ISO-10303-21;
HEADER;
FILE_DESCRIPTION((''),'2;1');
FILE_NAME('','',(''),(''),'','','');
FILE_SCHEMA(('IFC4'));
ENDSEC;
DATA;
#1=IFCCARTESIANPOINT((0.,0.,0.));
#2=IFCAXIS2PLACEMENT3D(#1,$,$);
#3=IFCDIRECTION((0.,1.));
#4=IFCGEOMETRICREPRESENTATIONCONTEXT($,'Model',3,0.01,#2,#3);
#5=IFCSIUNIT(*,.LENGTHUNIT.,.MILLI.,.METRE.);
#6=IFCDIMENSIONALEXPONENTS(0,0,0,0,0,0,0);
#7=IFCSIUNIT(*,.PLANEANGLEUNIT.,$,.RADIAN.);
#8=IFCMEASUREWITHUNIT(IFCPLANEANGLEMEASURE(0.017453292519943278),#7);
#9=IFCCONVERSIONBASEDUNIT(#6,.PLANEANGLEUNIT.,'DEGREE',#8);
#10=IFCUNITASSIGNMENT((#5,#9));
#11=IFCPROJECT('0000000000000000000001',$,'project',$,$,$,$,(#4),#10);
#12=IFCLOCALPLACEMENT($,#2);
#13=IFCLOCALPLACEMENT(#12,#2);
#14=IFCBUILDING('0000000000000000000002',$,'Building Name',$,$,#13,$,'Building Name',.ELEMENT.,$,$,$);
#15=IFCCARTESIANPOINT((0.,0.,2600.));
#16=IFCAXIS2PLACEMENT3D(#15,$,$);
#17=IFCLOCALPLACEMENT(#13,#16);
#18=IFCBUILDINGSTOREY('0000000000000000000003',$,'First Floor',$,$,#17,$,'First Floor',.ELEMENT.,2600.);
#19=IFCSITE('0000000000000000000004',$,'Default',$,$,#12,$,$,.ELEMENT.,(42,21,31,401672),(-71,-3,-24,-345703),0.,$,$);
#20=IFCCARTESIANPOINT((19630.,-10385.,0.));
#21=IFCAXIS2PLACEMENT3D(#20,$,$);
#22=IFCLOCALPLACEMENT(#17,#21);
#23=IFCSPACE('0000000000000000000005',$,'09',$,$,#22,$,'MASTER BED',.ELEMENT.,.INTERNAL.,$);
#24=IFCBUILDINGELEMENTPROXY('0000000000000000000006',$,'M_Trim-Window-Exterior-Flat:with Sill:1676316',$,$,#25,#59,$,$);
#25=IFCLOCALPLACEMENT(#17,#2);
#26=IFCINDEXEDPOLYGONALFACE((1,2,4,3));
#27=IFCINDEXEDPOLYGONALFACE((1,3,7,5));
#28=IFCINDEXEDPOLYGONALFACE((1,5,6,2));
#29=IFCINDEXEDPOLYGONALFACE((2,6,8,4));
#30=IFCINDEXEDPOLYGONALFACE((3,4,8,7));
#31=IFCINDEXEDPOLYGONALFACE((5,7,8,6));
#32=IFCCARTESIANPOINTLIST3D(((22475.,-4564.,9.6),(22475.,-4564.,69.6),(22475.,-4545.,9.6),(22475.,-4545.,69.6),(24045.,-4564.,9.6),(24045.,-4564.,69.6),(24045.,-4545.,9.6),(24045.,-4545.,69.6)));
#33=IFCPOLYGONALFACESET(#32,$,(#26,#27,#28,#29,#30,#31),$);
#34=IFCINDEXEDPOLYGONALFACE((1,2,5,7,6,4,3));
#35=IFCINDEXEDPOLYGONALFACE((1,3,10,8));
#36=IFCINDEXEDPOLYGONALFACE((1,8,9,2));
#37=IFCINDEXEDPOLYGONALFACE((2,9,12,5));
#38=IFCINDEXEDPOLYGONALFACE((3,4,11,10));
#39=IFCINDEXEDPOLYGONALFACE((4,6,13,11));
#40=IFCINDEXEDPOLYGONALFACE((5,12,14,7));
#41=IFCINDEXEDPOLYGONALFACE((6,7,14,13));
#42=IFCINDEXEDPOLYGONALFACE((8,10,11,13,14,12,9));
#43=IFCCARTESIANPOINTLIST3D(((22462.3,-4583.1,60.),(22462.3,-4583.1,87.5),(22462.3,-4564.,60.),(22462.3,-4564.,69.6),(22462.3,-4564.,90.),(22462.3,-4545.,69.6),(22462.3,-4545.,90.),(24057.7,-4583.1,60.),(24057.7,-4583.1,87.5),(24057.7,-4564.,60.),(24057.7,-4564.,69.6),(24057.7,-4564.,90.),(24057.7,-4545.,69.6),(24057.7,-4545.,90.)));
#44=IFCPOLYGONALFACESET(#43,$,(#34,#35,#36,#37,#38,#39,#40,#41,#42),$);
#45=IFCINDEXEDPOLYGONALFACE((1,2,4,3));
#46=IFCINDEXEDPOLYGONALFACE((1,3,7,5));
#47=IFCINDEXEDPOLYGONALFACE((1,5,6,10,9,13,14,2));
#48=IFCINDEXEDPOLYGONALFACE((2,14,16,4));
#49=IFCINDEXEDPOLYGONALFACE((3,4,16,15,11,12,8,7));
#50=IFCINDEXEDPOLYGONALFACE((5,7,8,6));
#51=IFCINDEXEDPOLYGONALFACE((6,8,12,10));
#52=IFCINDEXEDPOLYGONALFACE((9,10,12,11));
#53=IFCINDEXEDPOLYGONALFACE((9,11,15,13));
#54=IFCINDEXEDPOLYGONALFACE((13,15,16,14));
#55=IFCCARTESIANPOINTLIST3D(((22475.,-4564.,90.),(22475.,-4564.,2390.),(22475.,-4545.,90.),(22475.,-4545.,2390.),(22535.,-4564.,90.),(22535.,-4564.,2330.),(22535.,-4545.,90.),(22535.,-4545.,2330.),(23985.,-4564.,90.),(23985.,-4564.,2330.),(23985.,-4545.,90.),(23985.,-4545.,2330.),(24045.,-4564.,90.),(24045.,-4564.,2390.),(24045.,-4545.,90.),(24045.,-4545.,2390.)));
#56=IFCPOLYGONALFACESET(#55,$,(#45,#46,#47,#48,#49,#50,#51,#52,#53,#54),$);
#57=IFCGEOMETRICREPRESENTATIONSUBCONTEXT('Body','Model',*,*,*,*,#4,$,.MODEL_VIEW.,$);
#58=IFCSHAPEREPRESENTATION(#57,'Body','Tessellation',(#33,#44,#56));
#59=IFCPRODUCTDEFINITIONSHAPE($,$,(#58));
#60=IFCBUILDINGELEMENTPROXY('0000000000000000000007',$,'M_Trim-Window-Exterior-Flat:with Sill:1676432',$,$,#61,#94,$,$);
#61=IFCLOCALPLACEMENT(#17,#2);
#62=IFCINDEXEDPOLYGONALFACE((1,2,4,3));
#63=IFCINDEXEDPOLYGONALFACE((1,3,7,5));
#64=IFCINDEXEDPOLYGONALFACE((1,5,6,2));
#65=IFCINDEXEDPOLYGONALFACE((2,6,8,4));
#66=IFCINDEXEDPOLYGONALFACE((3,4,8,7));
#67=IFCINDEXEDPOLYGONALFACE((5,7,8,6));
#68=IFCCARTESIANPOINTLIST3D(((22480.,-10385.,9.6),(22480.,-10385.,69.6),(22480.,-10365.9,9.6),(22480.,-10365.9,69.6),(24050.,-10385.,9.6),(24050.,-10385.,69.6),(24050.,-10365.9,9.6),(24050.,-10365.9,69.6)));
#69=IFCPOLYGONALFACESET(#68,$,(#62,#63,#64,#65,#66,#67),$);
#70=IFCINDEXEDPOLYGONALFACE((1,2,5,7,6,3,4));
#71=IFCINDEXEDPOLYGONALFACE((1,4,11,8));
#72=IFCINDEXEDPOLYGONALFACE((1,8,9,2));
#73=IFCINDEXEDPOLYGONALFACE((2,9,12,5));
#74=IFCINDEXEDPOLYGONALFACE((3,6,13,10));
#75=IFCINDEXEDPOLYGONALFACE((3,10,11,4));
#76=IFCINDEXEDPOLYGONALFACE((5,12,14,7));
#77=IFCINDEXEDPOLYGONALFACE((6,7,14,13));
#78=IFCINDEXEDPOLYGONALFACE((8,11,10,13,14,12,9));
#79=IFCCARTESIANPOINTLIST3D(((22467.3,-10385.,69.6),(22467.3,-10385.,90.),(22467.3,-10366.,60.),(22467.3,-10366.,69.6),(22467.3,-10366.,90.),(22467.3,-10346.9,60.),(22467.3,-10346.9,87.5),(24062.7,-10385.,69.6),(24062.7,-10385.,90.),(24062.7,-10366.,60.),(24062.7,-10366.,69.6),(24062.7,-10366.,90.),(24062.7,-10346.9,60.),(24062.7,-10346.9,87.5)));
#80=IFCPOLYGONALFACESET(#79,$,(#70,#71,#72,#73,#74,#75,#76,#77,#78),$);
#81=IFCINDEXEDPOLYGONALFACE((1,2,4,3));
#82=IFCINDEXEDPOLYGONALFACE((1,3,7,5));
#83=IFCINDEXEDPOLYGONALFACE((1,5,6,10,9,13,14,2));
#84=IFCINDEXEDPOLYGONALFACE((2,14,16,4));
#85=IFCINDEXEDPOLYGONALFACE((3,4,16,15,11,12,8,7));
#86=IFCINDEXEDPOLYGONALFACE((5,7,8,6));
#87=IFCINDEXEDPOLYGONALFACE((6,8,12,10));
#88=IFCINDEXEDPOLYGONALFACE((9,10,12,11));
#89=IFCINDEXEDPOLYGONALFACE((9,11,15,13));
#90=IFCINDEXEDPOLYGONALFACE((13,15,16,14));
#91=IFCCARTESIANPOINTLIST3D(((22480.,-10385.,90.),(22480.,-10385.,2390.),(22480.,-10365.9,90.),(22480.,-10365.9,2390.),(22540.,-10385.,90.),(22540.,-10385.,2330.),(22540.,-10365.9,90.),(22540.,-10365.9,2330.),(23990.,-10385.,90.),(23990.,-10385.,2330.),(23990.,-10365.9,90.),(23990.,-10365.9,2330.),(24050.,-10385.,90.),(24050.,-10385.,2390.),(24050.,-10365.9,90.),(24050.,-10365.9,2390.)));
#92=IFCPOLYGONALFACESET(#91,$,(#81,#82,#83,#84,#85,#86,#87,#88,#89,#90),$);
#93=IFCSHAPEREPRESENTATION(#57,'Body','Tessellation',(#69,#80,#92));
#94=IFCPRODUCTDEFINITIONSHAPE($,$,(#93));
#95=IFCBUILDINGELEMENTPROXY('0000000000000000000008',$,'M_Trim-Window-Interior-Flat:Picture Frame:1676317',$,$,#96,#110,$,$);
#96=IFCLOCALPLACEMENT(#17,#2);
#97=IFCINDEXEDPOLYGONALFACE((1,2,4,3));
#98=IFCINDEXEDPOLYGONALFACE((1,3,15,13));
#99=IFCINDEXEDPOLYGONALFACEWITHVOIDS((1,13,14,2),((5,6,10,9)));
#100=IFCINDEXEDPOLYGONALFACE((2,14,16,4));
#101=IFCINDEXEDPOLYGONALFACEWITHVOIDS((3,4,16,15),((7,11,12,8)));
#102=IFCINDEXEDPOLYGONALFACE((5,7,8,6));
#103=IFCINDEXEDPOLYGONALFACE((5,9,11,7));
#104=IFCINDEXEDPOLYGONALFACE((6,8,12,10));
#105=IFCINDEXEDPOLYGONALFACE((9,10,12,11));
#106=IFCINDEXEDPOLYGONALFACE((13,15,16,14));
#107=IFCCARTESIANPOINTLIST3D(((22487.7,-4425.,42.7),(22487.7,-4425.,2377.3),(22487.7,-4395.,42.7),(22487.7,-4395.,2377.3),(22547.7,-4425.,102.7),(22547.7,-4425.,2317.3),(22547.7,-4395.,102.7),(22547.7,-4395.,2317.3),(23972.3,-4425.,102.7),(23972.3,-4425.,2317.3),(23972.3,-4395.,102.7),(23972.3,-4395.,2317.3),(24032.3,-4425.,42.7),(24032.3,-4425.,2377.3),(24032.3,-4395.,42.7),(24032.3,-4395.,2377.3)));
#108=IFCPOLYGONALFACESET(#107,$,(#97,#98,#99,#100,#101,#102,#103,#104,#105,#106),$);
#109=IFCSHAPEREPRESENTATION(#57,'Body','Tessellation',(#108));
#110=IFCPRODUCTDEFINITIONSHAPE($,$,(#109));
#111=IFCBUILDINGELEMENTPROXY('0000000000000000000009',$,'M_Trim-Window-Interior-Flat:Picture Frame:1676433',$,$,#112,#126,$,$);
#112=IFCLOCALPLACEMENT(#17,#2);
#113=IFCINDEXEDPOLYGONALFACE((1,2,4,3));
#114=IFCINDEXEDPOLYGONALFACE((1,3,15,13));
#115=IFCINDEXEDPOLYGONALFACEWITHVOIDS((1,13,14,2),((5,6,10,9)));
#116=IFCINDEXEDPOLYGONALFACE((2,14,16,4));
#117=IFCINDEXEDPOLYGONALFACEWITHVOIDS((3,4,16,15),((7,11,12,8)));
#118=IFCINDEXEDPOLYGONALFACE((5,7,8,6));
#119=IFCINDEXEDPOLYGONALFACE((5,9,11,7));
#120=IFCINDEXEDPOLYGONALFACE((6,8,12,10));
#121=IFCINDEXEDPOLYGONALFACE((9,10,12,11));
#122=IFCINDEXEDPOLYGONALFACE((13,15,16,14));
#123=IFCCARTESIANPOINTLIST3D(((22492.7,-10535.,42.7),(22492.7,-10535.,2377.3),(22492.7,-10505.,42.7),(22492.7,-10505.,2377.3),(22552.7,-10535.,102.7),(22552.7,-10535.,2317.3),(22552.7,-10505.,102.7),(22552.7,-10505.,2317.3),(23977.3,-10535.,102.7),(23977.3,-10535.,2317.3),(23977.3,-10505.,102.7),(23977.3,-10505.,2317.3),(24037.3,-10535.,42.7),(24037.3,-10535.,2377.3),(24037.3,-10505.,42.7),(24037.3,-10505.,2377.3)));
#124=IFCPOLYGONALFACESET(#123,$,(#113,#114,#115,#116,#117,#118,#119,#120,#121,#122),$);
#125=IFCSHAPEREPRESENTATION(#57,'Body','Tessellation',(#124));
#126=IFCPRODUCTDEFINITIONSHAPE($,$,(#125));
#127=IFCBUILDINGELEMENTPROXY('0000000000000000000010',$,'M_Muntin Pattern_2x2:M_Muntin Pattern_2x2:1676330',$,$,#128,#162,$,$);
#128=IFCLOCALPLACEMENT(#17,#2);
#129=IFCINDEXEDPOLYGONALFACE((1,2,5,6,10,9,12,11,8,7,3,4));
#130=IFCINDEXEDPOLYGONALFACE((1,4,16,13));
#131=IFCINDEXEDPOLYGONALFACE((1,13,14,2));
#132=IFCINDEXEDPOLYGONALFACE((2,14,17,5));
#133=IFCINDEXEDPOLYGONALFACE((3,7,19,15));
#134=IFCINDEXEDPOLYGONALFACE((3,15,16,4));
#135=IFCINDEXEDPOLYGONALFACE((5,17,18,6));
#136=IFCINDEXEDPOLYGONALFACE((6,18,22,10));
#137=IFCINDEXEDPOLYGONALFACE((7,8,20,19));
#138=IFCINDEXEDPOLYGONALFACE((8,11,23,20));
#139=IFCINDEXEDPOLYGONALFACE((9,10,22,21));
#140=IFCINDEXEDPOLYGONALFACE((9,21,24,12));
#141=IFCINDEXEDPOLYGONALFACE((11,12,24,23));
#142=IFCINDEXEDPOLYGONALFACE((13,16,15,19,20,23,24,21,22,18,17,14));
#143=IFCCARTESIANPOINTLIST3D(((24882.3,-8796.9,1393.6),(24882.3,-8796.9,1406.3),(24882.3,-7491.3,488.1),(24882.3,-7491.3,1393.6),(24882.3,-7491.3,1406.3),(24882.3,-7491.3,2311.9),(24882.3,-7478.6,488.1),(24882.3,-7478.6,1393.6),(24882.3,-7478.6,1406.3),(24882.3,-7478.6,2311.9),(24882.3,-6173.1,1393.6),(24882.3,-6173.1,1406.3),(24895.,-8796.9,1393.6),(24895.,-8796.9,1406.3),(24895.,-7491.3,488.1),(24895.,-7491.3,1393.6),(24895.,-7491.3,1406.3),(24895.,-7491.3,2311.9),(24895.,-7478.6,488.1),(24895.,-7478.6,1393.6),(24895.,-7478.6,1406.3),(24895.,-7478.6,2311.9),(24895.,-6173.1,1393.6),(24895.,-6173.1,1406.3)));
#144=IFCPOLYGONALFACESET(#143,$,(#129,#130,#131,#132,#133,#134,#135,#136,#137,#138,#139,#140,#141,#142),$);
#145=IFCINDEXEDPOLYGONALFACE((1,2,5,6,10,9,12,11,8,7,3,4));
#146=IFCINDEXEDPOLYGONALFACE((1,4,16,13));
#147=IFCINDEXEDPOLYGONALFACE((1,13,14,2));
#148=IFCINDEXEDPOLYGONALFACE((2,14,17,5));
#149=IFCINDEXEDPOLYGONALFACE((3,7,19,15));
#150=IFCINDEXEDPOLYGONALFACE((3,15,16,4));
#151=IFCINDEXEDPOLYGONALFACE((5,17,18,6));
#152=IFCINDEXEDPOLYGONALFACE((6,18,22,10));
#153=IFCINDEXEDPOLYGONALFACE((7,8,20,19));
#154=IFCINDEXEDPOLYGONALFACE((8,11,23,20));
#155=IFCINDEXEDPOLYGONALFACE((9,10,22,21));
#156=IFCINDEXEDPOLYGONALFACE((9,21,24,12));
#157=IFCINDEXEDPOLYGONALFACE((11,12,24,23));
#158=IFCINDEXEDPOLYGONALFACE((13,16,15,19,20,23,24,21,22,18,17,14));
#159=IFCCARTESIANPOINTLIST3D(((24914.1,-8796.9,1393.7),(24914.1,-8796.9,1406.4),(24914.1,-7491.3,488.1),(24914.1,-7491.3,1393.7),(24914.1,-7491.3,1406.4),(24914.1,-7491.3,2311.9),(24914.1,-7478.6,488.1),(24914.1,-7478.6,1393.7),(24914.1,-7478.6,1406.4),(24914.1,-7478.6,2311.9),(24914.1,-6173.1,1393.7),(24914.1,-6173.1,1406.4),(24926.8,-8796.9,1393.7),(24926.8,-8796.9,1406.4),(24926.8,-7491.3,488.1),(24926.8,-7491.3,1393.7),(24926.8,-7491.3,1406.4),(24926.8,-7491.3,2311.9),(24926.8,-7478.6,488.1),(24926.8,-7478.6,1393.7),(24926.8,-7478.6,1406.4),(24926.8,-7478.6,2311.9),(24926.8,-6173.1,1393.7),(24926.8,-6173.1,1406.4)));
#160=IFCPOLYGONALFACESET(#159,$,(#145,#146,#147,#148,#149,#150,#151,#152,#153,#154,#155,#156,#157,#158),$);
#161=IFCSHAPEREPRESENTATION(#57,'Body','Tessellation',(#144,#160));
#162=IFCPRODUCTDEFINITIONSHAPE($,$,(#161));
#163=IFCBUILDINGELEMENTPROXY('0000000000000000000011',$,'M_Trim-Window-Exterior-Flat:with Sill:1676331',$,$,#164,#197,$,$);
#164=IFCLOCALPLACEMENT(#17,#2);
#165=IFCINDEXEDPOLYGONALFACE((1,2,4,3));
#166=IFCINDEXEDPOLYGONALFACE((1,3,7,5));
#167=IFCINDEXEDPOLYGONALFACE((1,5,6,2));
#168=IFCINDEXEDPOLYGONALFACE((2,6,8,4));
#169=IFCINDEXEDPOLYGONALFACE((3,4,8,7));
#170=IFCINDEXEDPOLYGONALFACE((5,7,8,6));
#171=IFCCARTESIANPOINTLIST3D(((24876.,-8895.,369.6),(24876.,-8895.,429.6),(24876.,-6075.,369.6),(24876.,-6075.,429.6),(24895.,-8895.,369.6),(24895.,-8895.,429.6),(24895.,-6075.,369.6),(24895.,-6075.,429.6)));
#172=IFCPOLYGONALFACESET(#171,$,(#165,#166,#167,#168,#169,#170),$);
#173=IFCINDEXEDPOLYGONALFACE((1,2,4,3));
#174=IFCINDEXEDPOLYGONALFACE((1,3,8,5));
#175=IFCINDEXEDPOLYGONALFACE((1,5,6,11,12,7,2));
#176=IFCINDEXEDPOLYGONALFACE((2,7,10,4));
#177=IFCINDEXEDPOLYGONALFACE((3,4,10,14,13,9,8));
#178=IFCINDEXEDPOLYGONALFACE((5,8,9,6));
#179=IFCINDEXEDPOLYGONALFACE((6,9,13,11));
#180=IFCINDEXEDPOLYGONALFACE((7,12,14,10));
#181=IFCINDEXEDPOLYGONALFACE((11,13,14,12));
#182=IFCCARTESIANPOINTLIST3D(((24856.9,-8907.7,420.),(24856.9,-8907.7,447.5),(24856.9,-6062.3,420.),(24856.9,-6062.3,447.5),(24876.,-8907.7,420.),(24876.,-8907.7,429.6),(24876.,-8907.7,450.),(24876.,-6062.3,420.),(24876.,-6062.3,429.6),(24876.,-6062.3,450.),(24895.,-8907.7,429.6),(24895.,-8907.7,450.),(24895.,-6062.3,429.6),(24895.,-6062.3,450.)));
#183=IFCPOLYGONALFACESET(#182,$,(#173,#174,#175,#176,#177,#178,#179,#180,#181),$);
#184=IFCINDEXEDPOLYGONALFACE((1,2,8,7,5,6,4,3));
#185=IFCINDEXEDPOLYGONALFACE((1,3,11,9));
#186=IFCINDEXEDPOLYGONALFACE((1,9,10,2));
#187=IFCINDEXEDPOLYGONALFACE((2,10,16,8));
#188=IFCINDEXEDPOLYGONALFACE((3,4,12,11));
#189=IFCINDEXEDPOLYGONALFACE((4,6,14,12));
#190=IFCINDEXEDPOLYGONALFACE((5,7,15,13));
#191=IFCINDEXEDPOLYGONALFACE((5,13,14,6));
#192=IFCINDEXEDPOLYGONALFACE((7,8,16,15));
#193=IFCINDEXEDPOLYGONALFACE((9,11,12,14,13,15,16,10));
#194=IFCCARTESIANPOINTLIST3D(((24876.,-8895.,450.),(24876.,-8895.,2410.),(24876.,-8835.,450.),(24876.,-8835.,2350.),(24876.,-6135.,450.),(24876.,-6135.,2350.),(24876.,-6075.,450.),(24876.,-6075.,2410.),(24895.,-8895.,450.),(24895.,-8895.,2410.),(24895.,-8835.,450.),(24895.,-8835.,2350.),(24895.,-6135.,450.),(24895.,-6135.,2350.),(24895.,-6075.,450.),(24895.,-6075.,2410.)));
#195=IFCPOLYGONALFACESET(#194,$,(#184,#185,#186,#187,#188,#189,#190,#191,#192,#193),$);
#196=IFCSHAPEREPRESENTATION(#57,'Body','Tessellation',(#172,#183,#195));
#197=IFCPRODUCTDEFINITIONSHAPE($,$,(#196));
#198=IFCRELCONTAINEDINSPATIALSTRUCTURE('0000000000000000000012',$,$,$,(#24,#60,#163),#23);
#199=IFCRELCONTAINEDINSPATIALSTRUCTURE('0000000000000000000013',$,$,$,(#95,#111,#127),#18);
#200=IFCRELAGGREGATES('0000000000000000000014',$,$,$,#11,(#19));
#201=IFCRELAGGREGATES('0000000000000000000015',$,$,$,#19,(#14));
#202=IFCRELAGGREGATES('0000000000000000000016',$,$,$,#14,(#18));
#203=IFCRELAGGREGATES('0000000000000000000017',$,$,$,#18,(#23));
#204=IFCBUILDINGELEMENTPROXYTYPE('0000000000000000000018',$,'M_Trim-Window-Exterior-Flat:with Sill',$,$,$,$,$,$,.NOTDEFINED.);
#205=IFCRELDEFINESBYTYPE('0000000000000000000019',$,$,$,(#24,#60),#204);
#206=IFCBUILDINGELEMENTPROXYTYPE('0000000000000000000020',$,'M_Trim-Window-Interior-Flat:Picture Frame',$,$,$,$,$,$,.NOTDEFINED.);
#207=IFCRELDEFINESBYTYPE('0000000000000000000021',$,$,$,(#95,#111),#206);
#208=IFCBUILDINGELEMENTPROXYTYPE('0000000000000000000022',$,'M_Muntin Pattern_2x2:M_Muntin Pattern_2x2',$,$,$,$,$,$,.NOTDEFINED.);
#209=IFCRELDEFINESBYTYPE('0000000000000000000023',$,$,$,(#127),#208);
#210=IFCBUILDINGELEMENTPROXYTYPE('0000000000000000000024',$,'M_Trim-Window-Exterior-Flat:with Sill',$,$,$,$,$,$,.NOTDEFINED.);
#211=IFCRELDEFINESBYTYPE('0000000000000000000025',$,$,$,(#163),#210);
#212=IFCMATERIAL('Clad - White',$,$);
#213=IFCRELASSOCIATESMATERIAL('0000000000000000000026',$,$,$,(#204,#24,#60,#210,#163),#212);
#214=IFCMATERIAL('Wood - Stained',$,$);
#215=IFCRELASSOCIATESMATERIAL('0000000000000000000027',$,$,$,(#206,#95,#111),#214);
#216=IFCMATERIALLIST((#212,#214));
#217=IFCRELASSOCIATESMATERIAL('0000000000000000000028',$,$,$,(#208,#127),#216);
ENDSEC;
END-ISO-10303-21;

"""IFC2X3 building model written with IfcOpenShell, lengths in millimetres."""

from ifc_helpers import new_model, entity, si_unit, converted_unit, direction, frame, frame_2d, origin, place, context, subcontext, project, spatial, polyline, rectangle, outline, extrude, source, transform, mapped, material, material_list, type_object, type_shapes, element, save


model = new_model("IFC2X3")

# Units and contexts
model_context = context("Model", 3, precision=0.01, world=origin(), true_north=direction((0.0, 1.0)))
body_context = subcontext(model_context, "Body", "Model", "MODEL_VIEW")
ifc_project = project(units=[si_unit("LENGTHUNIT", "METRE", prefix="MILLI"), converted_unit("PLANEANGLEUNIT", "DEGREE", entity("IfcPlaneAngleMeasure", 0.017453292519943278), si_unit("PLANEANGLEUNIT", "RADIAN"), dimensions=[0, 0, 0, 0, 0, 0, 0])], contexts=[model_context])

# Site, building, storey
site_placement = place(None, origin())
site = spatial("IfcSite", under=ifc_project, at=site_placement, Name="Default", CompositionType="ELEMENT", RefLatitude=(42, 21, 31, 401672), RefLongitude=(-71, -3, -24, -345703), RefElevation=0.0)
building_placement = place(site_placement, origin())
building = spatial("IfcBuilding", under=site, at=building_placement, Name="Building Name", LongName="Building Name", CompositionType="ELEMENT")
storey_placement = place(building_placement, frame((0.0, 0.0, 2600.0)))
storey = spatial("IfcBuildingStorey", under=building, at=storey_placement, Name="First Floor", LongName="First Floor", CompositionType="ELEMENT", Elevation=2600.0)

# Shared definitions
space_placement = place(storey_placement, frame((19630.0, -10385.0, 0.0)))
space = spatial("IfcSpace", under=storey, at=space_placement, Name="09", LongName="MASTER BED", CompositionType="ELEMENT", InteriorOrExteriorSpace="INTERNAL")

# Building element proxies
ifc_material_1 = material(Name="Clad - White")
ifc_material_2 = material(Name="Wood - Stained")
ifc_material_list = material_list([ifc_material_1, ifc_material_2])
building_element_proxy_type_1 = type_object("IfcBuildingElementProxyType", Name="M_Trim-Window-Exterior-Flat:with Sill", PredefinedType="NOTDEFINED", material=ifc_material_1)
shared_shape_1 = source(origin(), body_context, "Body", "SweptSolid", [
    extrude(rectangle(XDim=1570.0, YDim=60.0, at=frame_2d((0.0, 0.0), x_axis=(1.0, 0.0))), frame((0.0, -2290.4, 0.0), z_axis=(0.0, 0.0, 1.0), x_axis=(-1.0, 0.0, 0.0)), (0.0, 0.0, 1.0), 19.0),
    extrude(outline(polyline([(-19.0, -15.2), (0.0, -15.2), (0.0, -5.7), (19.0, -5.7), (19.0, 14.8), (0.0, 14.8), (-19.0, 12.3), (-19.0, -15.2)])), frame((-797.7, -2254.8, 19.0), z_axis=(1.0, 0.0, 0.0), x_axis=(0.0, 0.0, -1.0)), (0.0, 0.0, 1.0), 1595.4),
    extrude(outline(polyline([(-1165.0, -785.0), (1135.0, -785.0), (1135.0, -725.0), (-1105.0, -725.0), (-1105.0, 725.0), (1135.0, 725.0), (1135.0, 785.0), (-1165.0, 785.0), (-1165.0, -785.0)])), frame((0.0, -1105.0, 0.0), z_axis=(0.0, 0.0, 1.0), x_axis=(0.0, -1.0, 0.0)), (0.0, 0.0, 1.0), 19.0),
])
type_shapes(building_element_proxy_type_1, [shared_shape_1])
for number, where, z_axis, x_axis, name in (
    (1, (3630.0, 5840.0, 2330.0), (0.0, -1.0, 0.0), (1.0, 0.0, 0.0), "M_Trim-Window-Exterior-Flat:with Sill:1676316"),
    (2, (3635.0, 0.0, 2330.0), (0.0, 1.0, 0.0), (-1.0, 0.0, 0.0), "M_Trim-Window-Exterior-Flat:with Sill:1676432"),
):
    element("IfcBuildingElementProxy", number, at=place(space_placement, frame(where, z_axis=z_axis, x_axis=x_axis)), inside=space, type_object=building_element_proxy_type_1, material=ifc_material_1, Name=name, context=body_context, shape_type="MappedRepresentation", body=[
        mapped(shared_shape_1, transform((0.0, 0.0, 0.0), scale=1.0)),
    ])
building_element_proxy_type_2 = type_object("IfcBuildingElementProxyType", Name="M_Trim-Window-Interior-Flat:Picture Frame", PredefinedType="NOTDEFINED", material=ifc_material_2)
shared_shape_2 = source(origin(), body_context, "Body", "SweptSolid", [
    extrude(outline(polyline([(-772.3, -1167.3), (772.3, -1167.3), (772.3, 1167.3), (-772.3, 1167.3), (-772.3, -1167.3)]), holes=[polyline([(-712.3, -1107.3), (-712.3, 1107.3), (712.3, 1107.3), (712.3, -1107.3), (-712.3, -1107.3)])]), frame((0.0, -1120.0, 0.0), z_axis=(0.0, 0.0, 1.0), x_axis=(-1.0, 0.0, 0.0)), (0.0, 0.0, 1.0), 30.0),
])
type_shapes(building_element_proxy_type_2, [shared_shape_2])
for number, where, z_axis, x_axis, name in (
    (3, (23260.0, -4425.0, 2330.0), (0.0, 1.0, 0.0), (-1.0, 0.0, 0.0), "M_Trim-Window-Interior-Flat:Picture Frame:1676317"),
    (4, (23265.0, -10505.0, 2330.0), (0.0, -1.0, 0.0), (1.0, 0.0, 0.0), "M_Trim-Window-Interior-Flat:Picture Frame:1676433"),
):
    element("IfcBuildingElementProxy", number, at=place(storey_placement, frame(where, z_axis=z_axis, x_axis=x_axis)), inside=storey, type_object=building_element_proxy_type_2, material=ifc_material_2, Name=name, context=body_context, shape_type="MappedRepresentation", body=[
        mapped(shared_shape_2, transform((0.0, 0.0, 0.0), scale=1.0)),
    ])
building_element_proxy_type_3 = type_object("IfcBuildingElementProxyType", Name="M_Muntin Pattern_2x2:M_Muntin Pattern_2x2", PredefinedType="NOTDEFINED", material=ifc_material_list)
shared_shape_3 = source(origin(), body_context, "Body", "SweptSolid", [
    extrude(outline(polyline([(6.4, -6.4), (911.9, -6.4), (911.9, 6.3), (6.4, 6.3), (6.4, 1311.9), (-6.3, 1311.9), (-6.3, 6.3), (-911.9, 6.3), (-911.9, -6.4), (-6.3, -6.4), (-6.3, -1311.9), (6.4, -1311.9), (6.4, -6.4)])), frame((0.0, -22.2, 911.9), z_axis=(0.0, 1.0, 0.0), x_axis=(0.0, 0.0, 1.0)), (0.0, 0.0, 1.0), 12.7),
    extrude(outline(polyline([(6.4, -6.4), (911.9, -6.4), (911.9, 6.3), (6.4, 6.3), (6.4, 1311.9), (-6.3, 1311.9), (-6.3, 6.3), (-911.9, 6.3), (-911.9, -6.4), (-6.3, -6.4), (-6.3, -1311.9), (6.4, -1311.9), (6.4, -6.4)])), frame((0.0, 9.5, 911.9), z_axis=(0.0, 1.0, 0.0), x_axis=(0.0, 0.0, 1.0)), (0.0, 0.0, 1.0), 12.7),
])
type_shapes(building_element_proxy_type_3, [shared_shape_3])
proxy_1_placement = place(storey_placement, frame((24904.5, -7485.0, 488.1), z_axis=(0.0, 0.0, 1.0), x_axis=(0.0, -1.0, 0.0)))
element("IfcBuildingElementProxy", 5, at=proxy_1_placement, inside=storey, type_object=building_element_proxy_type_3, material=ifc_material_list, Name="M_Muntin Pattern_2x2:M_Muntin Pattern_2x2:1676330", context=body_context, shape_type="MappedRepresentation", body=[
    mapped(shared_shape_3, transform((0.0, 0.0, 0.0), scale=1.0)),
])
building_element_proxy_type_4 = type_object("IfcBuildingElementProxyType", Name="M_Trim-Window-Exterior-Flat:with Sill", PredefinedType="NOTDEFINED", material=ifc_material_1)
shared_shape_4 = source(origin(), body_context, "Body", "SweptSolid", [
    extrude(rectangle(XDim=2820.0, YDim=60.0, at=frame_2d((0.0, 0.0), x_axis=(1.0, 0.0))), frame((0.0, -1950.4, 0.0), z_axis=(0.0, 0.0, 1.0), x_axis=(-1.0, 0.0, 0.0)), (0.0, 0.0, 1.0), 19.0),
    extrude(outline(polyline([(-19.0, -15.2), (0.0, -15.2), (0.0, -5.7), (19.0, -5.7), (19.0, 14.8), (0.0, 14.8), (-19.0, 12.3), (-19.0, -15.2)])), frame((-1422.7, -1914.8, 19.0), z_axis=(1.0, 0.0, 0.0), x_axis=(0.0, 0.0, -1.0)), (0.0, 0.0, 1.0), 2845.4),
    extrude(outline(polyline([(-995.0, -1410.0), (965.0, -1410.0), (965.0, -1350.0), (-935.0, -1350.0), (-935.0, 1350.0), (965.0, 1350.0), (965.0, 1410.0), (-995.0, 1410.0), (-995.0, -1410.0)])), frame((0.0, -935.0, 0.0), z_axis=(0.0, 0.0, 1.0), x_axis=(0.0, -1.0, 0.0)), (0.0, 0.0, 1.0), 19.0),
])
type_shapes(building_element_proxy_type_4, [shared_shape_4])
proxy_2_placement = place(space_placement, frame((5265.0, 2900.0, 2350.0), z_axis=(-1.0, 0.0, 0.0), x_axis=(0.0, -1.0, 0.0)))
element("IfcBuildingElementProxy", 6, at=proxy_2_placement, inside=space, type_object=building_element_proxy_type_4, material=ifc_material_1, Name="M_Trim-Window-Exterior-Flat:with Sill:1676331", context=body_context, shape_type="MappedRepresentation", body=[
    mapped(shared_shape_4, transform((0.0, 0.0, 0.0), scale=1.0)),
])

save(model, "model.ifc")
